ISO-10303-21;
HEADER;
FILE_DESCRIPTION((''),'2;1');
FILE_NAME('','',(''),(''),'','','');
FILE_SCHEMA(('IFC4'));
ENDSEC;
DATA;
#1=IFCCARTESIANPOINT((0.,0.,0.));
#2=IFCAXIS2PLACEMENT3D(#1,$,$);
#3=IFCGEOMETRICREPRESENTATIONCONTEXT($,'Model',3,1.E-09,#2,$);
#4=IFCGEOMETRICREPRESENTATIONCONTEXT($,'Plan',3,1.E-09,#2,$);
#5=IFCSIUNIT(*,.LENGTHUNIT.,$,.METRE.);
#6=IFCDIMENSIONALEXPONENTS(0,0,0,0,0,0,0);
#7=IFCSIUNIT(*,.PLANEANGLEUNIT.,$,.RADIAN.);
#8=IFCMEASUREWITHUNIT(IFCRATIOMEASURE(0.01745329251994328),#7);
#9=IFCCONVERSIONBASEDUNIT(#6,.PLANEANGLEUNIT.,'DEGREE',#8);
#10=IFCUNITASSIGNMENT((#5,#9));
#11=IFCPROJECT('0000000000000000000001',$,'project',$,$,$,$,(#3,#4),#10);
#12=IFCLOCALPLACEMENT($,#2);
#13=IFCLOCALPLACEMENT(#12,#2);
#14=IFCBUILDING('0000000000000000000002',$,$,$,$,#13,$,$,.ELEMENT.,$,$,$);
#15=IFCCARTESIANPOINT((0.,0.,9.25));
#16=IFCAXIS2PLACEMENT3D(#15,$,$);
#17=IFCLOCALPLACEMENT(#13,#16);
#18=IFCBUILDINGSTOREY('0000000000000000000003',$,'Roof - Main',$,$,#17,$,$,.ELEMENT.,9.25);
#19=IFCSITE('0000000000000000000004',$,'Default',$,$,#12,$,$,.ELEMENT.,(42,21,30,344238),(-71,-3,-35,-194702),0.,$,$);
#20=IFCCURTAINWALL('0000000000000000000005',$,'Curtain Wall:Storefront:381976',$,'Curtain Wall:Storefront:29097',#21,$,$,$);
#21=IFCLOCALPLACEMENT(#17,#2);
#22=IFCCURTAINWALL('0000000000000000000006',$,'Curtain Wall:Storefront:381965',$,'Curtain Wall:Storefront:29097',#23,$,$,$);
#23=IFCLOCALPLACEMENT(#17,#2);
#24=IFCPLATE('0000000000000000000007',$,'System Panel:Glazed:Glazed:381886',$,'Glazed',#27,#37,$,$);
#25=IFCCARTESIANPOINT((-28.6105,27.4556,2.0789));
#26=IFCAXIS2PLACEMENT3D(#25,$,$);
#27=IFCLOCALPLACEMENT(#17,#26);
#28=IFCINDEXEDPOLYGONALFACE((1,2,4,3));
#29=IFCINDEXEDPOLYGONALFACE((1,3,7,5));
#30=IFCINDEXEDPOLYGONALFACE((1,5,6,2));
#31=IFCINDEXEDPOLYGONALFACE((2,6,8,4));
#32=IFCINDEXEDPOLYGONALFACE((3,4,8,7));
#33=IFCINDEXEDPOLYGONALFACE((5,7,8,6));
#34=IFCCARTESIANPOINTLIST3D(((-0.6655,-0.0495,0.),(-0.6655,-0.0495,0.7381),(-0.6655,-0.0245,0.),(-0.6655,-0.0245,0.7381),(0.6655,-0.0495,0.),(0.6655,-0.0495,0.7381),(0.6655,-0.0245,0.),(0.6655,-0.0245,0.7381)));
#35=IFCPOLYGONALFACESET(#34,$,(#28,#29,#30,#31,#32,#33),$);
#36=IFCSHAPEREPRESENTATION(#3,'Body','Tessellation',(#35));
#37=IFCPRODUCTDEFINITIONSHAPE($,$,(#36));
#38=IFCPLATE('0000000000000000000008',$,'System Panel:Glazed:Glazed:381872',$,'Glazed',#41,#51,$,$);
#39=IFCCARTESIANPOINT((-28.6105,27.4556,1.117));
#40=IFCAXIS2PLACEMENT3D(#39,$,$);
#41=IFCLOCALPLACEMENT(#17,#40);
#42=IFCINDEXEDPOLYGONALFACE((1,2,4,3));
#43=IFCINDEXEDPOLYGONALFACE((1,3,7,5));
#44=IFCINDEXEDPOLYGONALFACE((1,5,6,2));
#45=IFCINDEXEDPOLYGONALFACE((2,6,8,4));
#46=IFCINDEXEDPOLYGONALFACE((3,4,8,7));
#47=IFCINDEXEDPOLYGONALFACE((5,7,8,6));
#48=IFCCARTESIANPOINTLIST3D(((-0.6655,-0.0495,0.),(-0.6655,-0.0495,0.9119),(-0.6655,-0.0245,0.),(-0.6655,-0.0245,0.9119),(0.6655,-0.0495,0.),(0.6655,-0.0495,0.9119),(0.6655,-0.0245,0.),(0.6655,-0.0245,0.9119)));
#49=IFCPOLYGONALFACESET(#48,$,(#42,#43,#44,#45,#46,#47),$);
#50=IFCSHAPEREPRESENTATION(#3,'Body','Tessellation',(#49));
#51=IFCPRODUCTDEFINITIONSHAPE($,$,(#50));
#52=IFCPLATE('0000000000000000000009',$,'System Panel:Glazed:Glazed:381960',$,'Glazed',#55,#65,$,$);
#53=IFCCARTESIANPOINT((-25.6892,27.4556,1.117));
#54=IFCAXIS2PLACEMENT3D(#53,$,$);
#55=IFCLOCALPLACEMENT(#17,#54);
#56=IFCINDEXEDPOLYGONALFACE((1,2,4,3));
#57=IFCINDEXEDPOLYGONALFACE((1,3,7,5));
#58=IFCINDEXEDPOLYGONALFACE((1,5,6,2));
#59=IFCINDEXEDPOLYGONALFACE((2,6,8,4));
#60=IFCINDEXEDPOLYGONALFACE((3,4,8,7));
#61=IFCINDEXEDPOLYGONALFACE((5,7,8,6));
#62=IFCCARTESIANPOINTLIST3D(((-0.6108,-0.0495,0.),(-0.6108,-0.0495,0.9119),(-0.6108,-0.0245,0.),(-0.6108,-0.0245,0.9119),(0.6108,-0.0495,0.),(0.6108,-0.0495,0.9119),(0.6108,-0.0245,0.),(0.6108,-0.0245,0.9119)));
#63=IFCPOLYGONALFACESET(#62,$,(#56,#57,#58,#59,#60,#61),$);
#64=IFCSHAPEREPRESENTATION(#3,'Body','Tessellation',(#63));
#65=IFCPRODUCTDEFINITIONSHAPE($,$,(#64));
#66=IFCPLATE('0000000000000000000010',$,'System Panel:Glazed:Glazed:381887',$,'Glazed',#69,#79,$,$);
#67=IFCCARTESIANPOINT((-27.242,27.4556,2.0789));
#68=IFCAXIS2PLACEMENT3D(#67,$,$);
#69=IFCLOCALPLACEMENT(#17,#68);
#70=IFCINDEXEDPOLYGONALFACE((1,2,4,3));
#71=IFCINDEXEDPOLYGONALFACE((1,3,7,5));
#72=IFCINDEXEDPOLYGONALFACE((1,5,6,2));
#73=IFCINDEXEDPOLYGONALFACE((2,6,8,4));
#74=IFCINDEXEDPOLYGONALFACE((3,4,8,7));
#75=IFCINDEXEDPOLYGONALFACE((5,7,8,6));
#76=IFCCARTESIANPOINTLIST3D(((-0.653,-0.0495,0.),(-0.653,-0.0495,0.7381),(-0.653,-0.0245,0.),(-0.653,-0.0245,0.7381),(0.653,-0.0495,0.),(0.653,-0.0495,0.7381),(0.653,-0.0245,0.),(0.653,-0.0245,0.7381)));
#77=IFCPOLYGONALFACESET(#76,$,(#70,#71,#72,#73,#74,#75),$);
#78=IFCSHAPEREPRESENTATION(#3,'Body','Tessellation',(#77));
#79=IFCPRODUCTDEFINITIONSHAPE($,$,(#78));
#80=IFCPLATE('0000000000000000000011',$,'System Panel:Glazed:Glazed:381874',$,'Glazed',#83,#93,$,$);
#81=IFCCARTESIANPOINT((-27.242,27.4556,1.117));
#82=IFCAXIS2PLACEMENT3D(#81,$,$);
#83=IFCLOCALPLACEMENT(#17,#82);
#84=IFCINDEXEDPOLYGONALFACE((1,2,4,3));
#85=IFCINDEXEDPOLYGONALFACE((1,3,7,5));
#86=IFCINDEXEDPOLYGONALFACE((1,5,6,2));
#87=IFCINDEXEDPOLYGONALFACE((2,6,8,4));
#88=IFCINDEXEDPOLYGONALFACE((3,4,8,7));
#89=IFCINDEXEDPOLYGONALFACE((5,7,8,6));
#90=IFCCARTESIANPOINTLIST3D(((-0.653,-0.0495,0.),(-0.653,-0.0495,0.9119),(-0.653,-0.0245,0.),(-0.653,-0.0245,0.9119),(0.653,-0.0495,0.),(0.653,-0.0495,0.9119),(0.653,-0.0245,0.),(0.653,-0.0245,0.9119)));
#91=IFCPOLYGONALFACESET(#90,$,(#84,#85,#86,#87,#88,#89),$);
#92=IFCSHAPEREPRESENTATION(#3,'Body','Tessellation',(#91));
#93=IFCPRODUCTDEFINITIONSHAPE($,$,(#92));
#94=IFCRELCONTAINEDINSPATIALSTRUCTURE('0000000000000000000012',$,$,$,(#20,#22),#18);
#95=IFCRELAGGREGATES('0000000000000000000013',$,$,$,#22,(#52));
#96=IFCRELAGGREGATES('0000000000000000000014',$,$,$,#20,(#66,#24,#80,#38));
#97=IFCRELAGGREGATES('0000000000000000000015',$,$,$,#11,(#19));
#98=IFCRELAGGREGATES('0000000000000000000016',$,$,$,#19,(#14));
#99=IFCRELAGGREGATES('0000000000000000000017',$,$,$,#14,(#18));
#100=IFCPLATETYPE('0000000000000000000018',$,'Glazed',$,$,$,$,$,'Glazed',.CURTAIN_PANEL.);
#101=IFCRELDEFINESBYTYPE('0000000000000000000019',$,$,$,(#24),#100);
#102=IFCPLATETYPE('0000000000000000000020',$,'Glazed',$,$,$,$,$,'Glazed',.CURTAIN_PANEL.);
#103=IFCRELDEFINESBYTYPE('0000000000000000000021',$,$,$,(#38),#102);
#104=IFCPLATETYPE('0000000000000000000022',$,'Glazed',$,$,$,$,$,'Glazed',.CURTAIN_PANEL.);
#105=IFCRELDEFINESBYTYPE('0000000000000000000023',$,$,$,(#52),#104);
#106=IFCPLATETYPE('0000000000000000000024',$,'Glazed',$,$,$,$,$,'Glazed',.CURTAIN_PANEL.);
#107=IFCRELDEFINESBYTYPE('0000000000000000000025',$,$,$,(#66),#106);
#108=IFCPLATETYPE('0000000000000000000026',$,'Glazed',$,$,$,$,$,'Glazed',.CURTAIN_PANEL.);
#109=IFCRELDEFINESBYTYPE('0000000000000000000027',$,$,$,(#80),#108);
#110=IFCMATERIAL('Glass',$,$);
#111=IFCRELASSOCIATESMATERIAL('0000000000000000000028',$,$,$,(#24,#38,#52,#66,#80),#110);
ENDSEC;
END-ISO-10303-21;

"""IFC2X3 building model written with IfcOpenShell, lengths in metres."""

from ifc_helpers import new_model, entity, si_unit, converted_unit, frame, origin, origin_2d_with_axis, place, context, project, spatial, rectangle, extrude, source, transform, mapped, material, type_object, type_shapes, element, aggregate, save


model = new_model("IFC2X3")

# Units and contexts
model_context = context("Model", 3, precision=1e-09, world=origin())
plan_context = context("Plan", 3, precision=1e-09, world=origin())
ifc_project = project(units=[si_unit("LENGTHUNIT", "METRE"), converted_unit("PLANEANGLEUNIT", "DEGREE", entity("IfcRatioMeasure", 0.01745329251994328), si_unit("PLANEANGLEUNIT", "RADIAN"), dimensions=[0, 0, 0, 0, 0, 0, 0])], contexts=[model_context, plan_context])

# Site, building, storey
site_placement = place(None, origin())
site = spatial("IfcSite", under=ifc_project, at=site_placement, Name="Default", CompositionType="ELEMENT", RefLatitude=(42, 21, 30, 344238), RefLongitude=(-71, -3, -35, -194702), RefElevation=0.0)
building_placement = place(site_placement, origin())
building = spatial("IfcBuilding", under=site, at=building_placement, CompositionType="ELEMENT")
storey_placement = place(building_placement, frame((0.0, 0.0, 9.25)))
storey = spatial("IfcBuildingStorey", under=building, at=storey_placement, Name="Roof - Main", CompositionType="ELEMENT", Elevation=9.25)

# Curtain walls
curtain_wall_1_placement = place(storey_placement, origin())
curtain_wall_1 = element("IfcCurtainWall", 1, at=curtain_wall_1_placement, inside=storey, Name="Curtain Wall:Storefront:381976", ObjectType="Curtain Wall:Storefront:29097")
curtain_wall_2_placement = place(storey_placement, origin())
curtain_wall_2 = element("IfcCurtainWall", 2, at=curtain_wall_2_placement, inside=storey, Name="Curtain Wall:Storefront:381965", ObjectType="Curtain Wall:Storefront:29097")

# Plates
ifc_material_1 = material(Name="Glass")
plate_type_1 = type_object("IfcPlateType", Name="Glazed", ElementType="Glazed", PredefinedType="CURTAIN_PANEL")
shared_shape_1 = source(origin(), model_context, "Body", "SweptSolid", [
    extrude(rectangle(XDim=0.025, YDim=1.331, at=origin_2d_with_axis()), frame((0.0, -0.037, 0.0), z_axis=(0.0, 0.0, 1.0), x_axis=(0.0, 1.0, 0.0)), (0.0, 0.0, 1.0), 0.7381),
])
type_shapes(plate_type_1, [shared_shape_1])
plate_1_placement = place(storey_placement, frame((-28.6105, 27.4556, 2.0789)))
plate_1 = element("IfcPlate", 3, at=plate_1_placement, type_object=plate_type_1, material=ifc_material_1, Name="System Panel:Glazed:Glazed:381886", ObjectType="Glazed", context=model_context, shape_type="MappedRepresentation", body=[
    mapped(shared_shape_1, transform((0.0, 0.0, 0.0), scale=1.0)),
])
plate_type_2 = type_object("IfcPlateType", Name="Glazed", ElementType="Glazed", PredefinedType="CURTAIN_PANEL")
shared_shape_2 = source(origin(), model_context, "Body", "SweptSolid", [
    extrude(rectangle(XDim=0.025, YDim=1.331, at=origin_2d_with_axis()), frame((0.0, -0.037, 0.0), z_axis=(0.0, 0.0, 1.0), x_axis=(0.0, 1.0, 0.0)), (0.0, 0.0, 1.0), 0.9119),
])
type_shapes(plate_type_2, [shared_shape_2])
plate_2_placement = place(storey_placement, frame((-28.6105, 27.4556, 1.117)))
plate_2 = element("IfcPlate", 4, at=plate_2_placement, type_object=plate_type_2, material=ifc_material_1, Name="System Panel:Glazed:Glazed:381872", ObjectType="Glazed", context=model_context, shape_type="MappedRepresentation", body=[
    mapped(shared_shape_2, transform((0.0, 0.0, 0.0), scale=1.0)),
])
plate_type_3 = type_object("IfcPlateType", Name="Glazed", ElementType="Glazed", PredefinedType="CURTAIN_PANEL")
shared_shape_3 = source(origin(), model_context, "Body", "SweptSolid", [
    extrude(rectangle(XDim=0.025, YDim=1.2217, at=origin_2d_with_axis()), frame((0.0, -0.037, 0.0), z_axis=(0.0, 0.0, 1.0), x_axis=(0.0, 1.0, 0.0)), (0.0, 0.0, 1.0), 0.9119),
])
type_shapes(plate_type_3, [shared_shape_3])
plate_3_placement = place(storey_placement, frame((-25.6892, 27.4556, 1.117)))
plate_3 = element("IfcPlate", 5, at=plate_3_placement, type_object=plate_type_3, material=ifc_material_1, Name="System Panel:Glazed:Glazed:381960", ObjectType="Glazed", context=model_context, shape_type="MappedRepresentation", body=[
    mapped(shared_shape_3, transform((0.0, 0.0, 0.0), scale=1.0)),
])
aggregate(curtain_wall_2, [plate_3])
plate_type_4 = type_object("IfcPlateType", Name="Glazed", ElementType="Glazed", PredefinedType="CURTAIN_PANEL")
shared_shape_4 = source(origin(), model_context, "Body", "SweptSolid", [
    extrude(rectangle(XDim=0.025, YDim=1.306, at=origin_2d_with_axis()), frame((0.0, -0.037, 0.0), z_axis=(0.0, 0.0, 1.0), x_axis=(0.0, 1.0, 0.0)), (0.0, 0.0, 1.0), 0.7381),
])
type_shapes(plate_type_4, [shared_shape_4])
plate_4_placement = place(storey_placement, frame((-27.242, 27.4556, 2.0789)))
plate_4 = element("IfcPlate", 6, at=plate_4_placement, type_object=plate_type_4, material=ifc_material_1, Name="System Panel:Glazed:Glazed:381887", ObjectType="Glazed", context=model_context, shape_type="MappedRepresentation", body=[
    mapped(shared_shape_4, transform((0.0, 0.0, 0.0), scale=1.0)),
])
plate_type_5 = type_object("IfcPlateType", Name="Glazed", ElementType="Glazed", PredefinedType="CURTAIN_PANEL")
shared_shape_5 = source(origin(), model_context, "Body", "SweptSolid", [
    extrude(rectangle(XDim=0.025, YDim=1.306, at=origin_2d_with_axis()), frame((0.0, -0.037, 0.0), z_axis=(0.0, 0.0, 1.0), x_axis=(0.0, 1.0, 0.0)), (0.0, 0.0, 1.0), 0.9119),
])
type_shapes(plate_type_5, [shared_shape_5])
plate_5_placement = place(storey_placement, frame((-27.242, 27.4556, 1.117)))
plate_5 = element("IfcPlate", 7, at=plate_5_placement, type_object=plate_type_5, material=ifc_material_1, Name="System Panel:Glazed:Glazed:381874", ObjectType="Glazed", context=model_context, shape_type="MappedRepresentation", body=[
    mapped(shared_shape_5, transform((0.0, 0.0, 0.0), scale=1.0)),
])
aggregate(curtain_wall_1, [plate_4, plate_1, plate_5, plate_2])

save(model, "model.ifc")
